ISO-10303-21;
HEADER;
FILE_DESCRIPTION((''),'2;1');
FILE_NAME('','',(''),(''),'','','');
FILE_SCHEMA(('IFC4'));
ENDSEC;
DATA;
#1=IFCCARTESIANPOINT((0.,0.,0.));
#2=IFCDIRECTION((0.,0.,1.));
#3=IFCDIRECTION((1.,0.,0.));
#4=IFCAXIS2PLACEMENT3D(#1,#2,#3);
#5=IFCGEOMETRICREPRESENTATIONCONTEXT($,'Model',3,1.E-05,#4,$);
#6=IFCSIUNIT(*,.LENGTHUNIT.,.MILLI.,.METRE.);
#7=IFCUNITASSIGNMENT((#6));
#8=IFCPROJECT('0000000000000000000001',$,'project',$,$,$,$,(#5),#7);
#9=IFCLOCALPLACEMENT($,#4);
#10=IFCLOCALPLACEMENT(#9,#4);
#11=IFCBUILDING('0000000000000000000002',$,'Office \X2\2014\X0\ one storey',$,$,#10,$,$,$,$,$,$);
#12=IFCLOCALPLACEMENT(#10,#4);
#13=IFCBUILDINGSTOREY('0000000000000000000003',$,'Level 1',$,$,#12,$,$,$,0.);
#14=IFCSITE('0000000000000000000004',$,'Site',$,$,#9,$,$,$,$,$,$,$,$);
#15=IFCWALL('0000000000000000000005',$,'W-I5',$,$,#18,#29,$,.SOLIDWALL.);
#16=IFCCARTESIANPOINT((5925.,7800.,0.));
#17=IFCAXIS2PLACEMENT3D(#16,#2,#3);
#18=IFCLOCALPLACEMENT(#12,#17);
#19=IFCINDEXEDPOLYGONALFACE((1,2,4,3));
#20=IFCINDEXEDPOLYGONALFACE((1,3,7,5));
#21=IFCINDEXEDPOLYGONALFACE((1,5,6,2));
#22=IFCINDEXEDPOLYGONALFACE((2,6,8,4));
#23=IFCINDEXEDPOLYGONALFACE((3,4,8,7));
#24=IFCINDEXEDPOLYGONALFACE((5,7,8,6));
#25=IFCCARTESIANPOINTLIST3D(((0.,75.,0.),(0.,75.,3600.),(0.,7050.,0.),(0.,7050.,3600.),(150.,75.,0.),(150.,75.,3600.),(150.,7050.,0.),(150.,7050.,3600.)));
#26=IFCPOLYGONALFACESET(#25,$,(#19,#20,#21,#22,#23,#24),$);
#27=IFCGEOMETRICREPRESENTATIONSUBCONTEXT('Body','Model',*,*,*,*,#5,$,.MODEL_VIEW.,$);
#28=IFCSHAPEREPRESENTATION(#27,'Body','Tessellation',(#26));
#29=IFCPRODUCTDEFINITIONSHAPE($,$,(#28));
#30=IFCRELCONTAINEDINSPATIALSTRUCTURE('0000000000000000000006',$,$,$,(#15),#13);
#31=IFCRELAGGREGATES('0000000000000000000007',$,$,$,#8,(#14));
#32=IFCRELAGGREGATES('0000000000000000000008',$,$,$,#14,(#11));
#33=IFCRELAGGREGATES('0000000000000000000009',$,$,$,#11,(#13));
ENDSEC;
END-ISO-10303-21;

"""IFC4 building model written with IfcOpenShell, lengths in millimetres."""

from ifc_helpers import new_model, si_unit, frame, frame_2d, origin, origin_with_axes, place, context, subcontext, project, spatial, rectangle, extrude, element, save


model = new_model("IFC4")

# Units and contexts
model_context = context("Model", 3, precision=1e-05, world=origin_with_axes())
body_context = subcontext(model_context, "Body", "Model", "MODEL_VIEW")
ifc_project = project(units=[si_unit("LENGTHUNIT", "METRE", prefix="MILLI")], contexts=[model_context])

# Site, building, storey
site_placement = place(None, origin_with_axes())
site = spatial("IfcSite", under=ifc_project, at=site_placement, Name="Site")
building_placement = place(site_placement, origin_with_axes())
building = spatial("IfcBuilding", under=site, at=building_placement, Name="Office — one storey")
storey_placement = place(building_placement, origin_with_axes())
storey = spatial("IfcBuildingStorey", under=building, at=storey_placement, Name="Level 1", Elevation=0.0)

# Wall
wall_1_placement = place(storey_placement, frame((5925.0, 7800.0, 0.0), z_axis=(0.0, 0.0, 1.0), x_axis=(1.0, 0.0, 0.0)))
element("IfcWall", 1, at=wall_1_placement, inside=storey, Name="W-I5", PredefinedType="SOLIDWALL", context=body_context, shape_type="SweptSolid", body=[
    extrude(rectangle(XDim=150.0, YDim=6975.0, at=frame_2d((75.0, 3562.5))), origin(), (0.0, 0.0, 1.0), 3600.0),
])

save(model, "model.ifc")
